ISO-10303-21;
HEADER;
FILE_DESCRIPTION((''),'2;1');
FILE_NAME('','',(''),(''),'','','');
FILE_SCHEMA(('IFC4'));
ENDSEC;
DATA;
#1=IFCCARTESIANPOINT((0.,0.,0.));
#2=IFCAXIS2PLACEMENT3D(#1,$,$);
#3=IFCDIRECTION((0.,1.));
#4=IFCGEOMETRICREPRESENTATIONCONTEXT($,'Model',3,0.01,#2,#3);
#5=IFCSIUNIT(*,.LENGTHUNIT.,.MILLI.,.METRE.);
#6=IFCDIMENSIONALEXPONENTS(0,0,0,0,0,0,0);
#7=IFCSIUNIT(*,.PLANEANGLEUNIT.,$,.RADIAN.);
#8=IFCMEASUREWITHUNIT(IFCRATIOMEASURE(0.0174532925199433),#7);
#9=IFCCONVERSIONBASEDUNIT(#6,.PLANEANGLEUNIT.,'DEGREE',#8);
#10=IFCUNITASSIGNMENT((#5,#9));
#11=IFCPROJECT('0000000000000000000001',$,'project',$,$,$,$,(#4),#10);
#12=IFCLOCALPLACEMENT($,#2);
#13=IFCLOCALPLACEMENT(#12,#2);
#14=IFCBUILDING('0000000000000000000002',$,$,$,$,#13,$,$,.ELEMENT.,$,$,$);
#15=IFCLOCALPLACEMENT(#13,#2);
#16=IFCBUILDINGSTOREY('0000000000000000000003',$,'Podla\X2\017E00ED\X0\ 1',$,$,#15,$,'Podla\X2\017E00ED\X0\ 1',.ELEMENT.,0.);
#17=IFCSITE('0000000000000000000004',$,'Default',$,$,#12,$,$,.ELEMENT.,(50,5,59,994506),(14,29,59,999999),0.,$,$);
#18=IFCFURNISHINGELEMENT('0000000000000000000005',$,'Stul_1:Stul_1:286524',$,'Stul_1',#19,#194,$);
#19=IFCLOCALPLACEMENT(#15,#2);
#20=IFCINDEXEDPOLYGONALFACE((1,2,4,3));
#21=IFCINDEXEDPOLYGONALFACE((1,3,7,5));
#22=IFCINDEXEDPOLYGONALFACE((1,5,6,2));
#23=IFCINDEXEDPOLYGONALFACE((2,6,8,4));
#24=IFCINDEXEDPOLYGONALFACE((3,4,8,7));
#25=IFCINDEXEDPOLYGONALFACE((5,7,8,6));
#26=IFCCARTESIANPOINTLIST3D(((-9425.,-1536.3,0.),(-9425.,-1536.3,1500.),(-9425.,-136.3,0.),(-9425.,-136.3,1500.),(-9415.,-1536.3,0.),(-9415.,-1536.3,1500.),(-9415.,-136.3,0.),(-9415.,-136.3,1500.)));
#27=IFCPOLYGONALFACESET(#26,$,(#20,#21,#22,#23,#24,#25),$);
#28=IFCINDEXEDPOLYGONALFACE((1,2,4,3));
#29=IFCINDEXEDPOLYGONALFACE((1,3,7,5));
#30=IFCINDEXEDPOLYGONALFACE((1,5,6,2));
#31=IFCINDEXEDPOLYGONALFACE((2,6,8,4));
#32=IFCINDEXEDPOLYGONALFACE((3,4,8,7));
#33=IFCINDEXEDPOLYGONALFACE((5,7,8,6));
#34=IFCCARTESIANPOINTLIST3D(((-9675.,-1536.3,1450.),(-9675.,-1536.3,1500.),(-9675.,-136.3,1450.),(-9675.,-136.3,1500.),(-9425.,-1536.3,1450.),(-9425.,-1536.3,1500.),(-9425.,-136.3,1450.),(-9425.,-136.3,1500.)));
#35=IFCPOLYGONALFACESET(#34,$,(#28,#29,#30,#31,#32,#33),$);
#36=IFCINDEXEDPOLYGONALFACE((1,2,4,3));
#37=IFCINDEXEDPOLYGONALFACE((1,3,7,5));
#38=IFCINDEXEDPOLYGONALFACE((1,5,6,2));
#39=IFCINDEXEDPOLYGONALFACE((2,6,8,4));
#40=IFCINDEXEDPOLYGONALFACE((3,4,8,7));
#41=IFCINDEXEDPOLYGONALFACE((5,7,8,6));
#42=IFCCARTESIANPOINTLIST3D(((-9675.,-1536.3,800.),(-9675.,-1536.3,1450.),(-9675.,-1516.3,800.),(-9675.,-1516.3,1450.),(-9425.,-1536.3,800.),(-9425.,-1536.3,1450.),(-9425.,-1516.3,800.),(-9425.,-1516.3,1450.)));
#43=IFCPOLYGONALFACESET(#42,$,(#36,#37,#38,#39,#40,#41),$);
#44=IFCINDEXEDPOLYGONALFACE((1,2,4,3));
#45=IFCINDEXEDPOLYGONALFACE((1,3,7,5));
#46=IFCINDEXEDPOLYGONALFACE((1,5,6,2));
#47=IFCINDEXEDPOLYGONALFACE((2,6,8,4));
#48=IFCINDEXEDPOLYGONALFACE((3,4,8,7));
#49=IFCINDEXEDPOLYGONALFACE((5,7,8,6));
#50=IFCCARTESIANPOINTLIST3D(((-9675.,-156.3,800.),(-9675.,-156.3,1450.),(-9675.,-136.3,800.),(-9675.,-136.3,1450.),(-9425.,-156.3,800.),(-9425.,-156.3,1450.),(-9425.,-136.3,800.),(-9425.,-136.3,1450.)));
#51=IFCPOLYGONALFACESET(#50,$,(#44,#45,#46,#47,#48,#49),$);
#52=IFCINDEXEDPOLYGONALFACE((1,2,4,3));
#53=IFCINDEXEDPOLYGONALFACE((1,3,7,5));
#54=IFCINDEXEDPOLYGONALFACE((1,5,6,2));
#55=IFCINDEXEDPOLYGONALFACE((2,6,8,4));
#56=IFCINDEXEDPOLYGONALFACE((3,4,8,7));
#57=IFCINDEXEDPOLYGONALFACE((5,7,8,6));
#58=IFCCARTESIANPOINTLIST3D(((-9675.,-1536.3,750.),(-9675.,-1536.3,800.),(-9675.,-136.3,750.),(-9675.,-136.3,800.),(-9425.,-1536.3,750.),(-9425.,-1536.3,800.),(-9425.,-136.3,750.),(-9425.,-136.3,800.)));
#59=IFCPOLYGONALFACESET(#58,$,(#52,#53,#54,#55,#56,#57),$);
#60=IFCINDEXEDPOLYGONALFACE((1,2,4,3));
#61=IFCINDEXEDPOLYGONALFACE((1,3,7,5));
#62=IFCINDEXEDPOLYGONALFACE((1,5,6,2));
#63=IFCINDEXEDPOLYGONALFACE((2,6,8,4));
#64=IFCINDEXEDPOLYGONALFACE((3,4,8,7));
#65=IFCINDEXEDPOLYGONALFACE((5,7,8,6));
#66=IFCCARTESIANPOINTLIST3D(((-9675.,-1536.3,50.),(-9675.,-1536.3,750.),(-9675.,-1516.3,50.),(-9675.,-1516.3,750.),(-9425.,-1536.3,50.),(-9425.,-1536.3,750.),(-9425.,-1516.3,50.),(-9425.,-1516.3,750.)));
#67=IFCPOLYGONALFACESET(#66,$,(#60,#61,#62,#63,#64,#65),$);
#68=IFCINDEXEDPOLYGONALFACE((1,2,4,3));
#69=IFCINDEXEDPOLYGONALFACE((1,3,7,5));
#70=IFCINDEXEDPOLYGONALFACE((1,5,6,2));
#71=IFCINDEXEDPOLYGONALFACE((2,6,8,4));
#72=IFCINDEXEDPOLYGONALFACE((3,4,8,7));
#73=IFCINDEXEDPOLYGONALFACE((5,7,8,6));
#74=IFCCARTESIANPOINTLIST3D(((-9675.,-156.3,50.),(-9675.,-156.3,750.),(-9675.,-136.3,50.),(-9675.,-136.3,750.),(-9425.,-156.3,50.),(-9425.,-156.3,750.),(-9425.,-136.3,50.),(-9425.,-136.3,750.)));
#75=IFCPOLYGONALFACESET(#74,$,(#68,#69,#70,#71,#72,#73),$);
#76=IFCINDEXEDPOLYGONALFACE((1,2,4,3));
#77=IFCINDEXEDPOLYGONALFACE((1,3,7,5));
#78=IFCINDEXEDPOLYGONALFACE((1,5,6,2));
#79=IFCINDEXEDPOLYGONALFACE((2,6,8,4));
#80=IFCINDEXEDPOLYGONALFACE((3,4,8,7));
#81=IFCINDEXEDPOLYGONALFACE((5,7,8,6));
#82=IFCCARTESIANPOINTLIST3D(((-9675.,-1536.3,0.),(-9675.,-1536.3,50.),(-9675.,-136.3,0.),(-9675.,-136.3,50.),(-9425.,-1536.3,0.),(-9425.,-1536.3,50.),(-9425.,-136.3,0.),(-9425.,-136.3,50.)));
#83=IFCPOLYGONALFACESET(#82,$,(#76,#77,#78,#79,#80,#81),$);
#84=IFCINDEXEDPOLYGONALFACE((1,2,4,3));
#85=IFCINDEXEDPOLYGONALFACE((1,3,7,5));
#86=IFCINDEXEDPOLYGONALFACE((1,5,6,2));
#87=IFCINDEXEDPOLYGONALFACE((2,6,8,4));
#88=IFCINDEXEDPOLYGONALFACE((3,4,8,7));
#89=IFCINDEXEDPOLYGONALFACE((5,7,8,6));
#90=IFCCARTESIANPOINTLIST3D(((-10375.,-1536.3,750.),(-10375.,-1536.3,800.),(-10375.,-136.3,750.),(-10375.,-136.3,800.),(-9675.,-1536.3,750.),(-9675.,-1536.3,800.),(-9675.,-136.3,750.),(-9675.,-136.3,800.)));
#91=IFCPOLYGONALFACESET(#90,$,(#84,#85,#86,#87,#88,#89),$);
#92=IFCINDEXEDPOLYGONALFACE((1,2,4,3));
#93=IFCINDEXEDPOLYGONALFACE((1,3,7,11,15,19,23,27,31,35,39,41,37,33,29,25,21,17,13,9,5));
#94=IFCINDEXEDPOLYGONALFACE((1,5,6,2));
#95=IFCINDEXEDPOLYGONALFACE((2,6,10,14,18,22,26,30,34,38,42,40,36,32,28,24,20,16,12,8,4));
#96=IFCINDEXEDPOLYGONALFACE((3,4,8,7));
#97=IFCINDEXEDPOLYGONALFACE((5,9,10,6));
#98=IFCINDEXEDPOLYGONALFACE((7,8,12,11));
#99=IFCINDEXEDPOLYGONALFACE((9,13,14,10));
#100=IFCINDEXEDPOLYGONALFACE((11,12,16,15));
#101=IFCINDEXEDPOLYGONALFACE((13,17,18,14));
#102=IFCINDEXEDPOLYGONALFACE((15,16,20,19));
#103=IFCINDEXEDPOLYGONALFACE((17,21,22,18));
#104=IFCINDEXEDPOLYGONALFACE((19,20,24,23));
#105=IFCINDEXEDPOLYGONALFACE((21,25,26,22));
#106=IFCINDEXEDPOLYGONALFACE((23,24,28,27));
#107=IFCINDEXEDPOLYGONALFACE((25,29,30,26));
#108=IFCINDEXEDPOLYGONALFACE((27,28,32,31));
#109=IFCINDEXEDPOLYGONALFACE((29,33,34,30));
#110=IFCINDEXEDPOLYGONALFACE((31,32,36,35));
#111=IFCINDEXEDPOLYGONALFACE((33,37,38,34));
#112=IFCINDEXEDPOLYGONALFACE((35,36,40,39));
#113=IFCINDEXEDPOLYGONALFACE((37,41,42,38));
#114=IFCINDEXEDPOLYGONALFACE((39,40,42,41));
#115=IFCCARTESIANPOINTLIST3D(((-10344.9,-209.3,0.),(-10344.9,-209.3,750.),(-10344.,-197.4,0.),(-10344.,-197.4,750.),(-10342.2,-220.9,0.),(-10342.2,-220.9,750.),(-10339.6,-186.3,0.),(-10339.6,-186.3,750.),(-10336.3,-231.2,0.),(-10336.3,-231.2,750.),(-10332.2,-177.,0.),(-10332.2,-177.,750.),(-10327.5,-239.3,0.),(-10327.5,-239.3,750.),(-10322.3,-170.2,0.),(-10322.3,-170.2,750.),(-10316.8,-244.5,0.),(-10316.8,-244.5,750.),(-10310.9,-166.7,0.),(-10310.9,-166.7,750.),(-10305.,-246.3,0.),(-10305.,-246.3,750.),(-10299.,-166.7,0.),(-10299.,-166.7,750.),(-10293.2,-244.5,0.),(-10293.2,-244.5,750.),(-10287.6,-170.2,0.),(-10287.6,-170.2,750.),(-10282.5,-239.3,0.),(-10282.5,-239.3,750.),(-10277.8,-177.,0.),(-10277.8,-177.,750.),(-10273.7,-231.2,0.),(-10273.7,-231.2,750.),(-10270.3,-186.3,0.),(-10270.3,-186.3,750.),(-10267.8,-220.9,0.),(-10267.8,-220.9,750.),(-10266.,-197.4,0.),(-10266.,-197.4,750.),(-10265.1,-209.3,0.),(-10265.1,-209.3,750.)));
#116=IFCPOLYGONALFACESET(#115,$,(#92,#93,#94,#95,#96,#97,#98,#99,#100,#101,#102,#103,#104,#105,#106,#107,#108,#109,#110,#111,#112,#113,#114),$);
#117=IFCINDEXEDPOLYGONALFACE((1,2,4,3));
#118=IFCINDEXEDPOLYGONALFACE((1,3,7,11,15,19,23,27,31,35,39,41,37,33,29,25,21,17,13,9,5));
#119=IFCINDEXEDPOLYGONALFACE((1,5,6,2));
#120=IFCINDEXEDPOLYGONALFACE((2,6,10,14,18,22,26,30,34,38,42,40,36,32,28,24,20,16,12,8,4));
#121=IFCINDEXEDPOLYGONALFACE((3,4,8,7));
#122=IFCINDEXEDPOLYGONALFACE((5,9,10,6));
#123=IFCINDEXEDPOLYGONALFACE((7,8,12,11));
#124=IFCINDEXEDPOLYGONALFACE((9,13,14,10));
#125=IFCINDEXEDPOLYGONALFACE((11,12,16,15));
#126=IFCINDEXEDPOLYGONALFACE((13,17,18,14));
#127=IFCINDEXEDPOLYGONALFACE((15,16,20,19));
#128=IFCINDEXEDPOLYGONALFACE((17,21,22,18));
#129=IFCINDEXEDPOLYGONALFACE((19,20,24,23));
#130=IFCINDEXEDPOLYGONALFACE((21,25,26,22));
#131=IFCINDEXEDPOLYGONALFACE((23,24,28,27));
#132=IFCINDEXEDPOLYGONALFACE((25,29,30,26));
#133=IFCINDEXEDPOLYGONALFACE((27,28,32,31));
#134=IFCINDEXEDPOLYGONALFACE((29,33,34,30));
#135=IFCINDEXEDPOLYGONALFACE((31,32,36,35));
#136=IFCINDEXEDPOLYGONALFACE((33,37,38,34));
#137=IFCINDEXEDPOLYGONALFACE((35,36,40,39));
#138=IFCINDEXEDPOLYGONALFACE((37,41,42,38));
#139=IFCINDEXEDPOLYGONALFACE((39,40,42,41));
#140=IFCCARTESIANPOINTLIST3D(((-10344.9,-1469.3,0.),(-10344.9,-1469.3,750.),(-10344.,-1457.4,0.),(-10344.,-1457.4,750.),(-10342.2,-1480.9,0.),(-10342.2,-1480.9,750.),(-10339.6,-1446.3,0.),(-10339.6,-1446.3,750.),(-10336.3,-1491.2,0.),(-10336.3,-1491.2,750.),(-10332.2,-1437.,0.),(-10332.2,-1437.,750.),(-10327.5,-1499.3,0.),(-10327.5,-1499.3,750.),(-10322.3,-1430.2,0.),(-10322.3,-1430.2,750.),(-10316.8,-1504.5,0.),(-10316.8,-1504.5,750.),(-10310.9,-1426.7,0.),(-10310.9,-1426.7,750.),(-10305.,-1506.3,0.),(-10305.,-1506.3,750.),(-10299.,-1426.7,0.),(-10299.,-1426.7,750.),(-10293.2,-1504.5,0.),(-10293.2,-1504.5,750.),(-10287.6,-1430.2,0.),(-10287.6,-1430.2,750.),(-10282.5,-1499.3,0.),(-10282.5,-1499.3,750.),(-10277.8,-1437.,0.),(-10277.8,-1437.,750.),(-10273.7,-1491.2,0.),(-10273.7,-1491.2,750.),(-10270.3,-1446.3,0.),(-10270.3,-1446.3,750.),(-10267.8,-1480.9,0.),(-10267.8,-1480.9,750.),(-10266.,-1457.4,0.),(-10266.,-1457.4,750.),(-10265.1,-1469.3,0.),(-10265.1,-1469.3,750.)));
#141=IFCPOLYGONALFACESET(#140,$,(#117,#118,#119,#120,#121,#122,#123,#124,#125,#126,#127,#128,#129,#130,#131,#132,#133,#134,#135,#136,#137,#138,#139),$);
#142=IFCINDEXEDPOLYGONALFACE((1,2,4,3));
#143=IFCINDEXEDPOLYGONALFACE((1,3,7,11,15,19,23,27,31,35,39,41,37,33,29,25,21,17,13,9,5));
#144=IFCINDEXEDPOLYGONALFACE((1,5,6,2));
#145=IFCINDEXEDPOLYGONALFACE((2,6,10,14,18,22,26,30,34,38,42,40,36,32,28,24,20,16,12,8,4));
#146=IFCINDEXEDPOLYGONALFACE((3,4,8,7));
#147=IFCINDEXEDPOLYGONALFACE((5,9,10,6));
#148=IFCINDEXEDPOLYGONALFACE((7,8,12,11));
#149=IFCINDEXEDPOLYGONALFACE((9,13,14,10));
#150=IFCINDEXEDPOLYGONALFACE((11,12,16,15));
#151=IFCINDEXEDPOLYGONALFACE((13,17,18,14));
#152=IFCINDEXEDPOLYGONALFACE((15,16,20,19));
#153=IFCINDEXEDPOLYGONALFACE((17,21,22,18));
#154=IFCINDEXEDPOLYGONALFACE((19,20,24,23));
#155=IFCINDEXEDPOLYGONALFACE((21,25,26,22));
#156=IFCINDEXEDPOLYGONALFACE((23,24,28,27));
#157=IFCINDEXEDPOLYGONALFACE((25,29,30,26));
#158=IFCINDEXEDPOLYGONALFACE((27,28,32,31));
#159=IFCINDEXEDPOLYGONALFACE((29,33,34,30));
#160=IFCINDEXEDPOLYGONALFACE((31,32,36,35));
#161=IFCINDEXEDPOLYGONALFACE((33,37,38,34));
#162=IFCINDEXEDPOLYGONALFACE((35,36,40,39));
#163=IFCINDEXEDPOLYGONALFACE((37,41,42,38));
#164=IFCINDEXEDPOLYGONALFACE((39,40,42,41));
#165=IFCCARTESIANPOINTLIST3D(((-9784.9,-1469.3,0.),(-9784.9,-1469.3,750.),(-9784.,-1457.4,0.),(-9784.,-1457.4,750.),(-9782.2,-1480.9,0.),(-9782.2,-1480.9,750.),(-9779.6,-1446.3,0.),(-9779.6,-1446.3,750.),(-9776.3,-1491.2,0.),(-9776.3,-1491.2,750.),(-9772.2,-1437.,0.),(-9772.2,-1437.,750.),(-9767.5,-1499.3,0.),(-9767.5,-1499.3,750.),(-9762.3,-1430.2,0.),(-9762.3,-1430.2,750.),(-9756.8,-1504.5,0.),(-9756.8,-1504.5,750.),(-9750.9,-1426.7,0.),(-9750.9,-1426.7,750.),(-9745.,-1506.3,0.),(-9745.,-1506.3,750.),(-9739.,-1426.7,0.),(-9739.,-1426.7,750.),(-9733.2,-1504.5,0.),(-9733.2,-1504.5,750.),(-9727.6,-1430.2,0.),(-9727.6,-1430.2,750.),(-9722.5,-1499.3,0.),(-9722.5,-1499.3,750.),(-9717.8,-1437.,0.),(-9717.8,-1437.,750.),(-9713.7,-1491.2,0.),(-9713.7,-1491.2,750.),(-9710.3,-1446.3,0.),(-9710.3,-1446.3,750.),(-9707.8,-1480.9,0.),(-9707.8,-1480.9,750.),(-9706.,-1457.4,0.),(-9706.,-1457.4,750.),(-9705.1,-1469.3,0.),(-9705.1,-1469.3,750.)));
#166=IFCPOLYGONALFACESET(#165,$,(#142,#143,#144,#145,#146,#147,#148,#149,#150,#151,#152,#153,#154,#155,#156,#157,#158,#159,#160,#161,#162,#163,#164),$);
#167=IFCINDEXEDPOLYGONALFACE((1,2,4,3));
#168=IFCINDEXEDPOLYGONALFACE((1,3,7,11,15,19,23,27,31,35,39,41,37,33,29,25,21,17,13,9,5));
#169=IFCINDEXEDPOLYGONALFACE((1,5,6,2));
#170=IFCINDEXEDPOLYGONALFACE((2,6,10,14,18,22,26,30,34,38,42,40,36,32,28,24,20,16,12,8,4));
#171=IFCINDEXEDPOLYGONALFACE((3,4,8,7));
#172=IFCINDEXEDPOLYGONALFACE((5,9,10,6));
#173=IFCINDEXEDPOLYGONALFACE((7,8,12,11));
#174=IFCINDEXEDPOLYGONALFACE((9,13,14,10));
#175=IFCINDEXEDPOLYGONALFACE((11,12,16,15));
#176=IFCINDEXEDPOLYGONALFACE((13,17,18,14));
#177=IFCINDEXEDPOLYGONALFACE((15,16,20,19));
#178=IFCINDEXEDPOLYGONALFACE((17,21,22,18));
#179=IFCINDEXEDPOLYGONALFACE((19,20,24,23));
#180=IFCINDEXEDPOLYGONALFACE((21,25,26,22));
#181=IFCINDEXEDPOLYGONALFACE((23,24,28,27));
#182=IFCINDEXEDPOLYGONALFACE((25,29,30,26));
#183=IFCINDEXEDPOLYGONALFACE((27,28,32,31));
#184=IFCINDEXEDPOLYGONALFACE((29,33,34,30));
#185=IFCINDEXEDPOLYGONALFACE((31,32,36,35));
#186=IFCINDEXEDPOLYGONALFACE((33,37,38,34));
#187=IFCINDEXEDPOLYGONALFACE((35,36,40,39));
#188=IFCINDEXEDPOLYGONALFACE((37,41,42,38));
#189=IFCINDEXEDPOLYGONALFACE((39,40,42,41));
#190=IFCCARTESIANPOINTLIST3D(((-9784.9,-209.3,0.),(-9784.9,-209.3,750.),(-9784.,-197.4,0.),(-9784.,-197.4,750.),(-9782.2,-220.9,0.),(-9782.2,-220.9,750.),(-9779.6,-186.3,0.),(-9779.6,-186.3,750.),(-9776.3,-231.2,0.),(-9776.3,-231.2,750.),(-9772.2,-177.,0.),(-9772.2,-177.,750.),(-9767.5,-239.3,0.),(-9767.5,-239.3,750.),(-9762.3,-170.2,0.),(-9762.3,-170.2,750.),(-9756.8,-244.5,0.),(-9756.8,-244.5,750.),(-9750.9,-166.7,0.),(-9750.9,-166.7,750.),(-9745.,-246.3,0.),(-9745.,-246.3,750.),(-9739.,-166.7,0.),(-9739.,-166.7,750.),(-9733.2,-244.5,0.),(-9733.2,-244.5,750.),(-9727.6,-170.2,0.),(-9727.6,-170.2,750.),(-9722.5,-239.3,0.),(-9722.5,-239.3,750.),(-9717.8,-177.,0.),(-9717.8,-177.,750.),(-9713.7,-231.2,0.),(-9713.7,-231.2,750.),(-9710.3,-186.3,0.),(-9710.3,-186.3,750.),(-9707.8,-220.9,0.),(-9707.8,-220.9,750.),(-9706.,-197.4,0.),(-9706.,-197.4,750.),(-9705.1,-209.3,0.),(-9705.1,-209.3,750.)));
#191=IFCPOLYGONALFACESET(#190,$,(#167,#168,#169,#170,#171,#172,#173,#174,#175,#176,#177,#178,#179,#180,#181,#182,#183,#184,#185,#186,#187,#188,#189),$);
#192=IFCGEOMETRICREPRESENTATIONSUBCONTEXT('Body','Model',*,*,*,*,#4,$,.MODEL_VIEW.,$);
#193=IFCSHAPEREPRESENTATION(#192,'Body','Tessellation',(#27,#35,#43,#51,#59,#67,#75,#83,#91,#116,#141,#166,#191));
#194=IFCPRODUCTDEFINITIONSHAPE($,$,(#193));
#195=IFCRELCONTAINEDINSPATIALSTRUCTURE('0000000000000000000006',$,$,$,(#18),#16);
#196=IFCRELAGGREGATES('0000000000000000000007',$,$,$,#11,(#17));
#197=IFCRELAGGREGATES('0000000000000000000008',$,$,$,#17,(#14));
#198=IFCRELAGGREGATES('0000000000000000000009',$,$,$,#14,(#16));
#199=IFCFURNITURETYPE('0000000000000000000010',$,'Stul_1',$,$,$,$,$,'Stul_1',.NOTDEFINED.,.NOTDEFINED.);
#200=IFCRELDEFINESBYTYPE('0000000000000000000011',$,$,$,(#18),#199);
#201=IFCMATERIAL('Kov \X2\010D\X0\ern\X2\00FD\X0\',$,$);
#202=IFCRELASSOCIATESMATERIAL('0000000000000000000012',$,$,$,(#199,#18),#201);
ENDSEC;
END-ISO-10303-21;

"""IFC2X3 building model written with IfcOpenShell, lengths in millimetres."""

from ifc_helpers import new_model, entity, si_unit, converted_unit, direction, frame, frame_2d, origin, origin_2d_with_axis, place, context, subcontext, project, spatial, rectangle, circle, extrude, source, transform, mapped, material, type_object, type_shapes, element, save


model = new_model("IFC2X3")

# Units and contexts
model_context = context("Model", 3, precision=0.01, world=origin(), true_north=direction((0.0, 1.0)))
body_context = subcontext(model_context, "Body", "Model", "MODEL_VIEW")
ifc_project = project(units=[si_unit("LENGTHUNIT", "METRE", prefix="MILLI"), converted_unit("PLANEANGLEUNIT", "DEGREE", entity("IfcRatioMeasure", 0.0174532925199433), si_unit("PLANEANGLEUNIT", "RADIAN"), dimensions=[0, 0, 0, 0, 0, 0, 0])], contexts=[model_context])

# Site, building, storey
site_placement = place(None, origin())
site = spatial("IfcSite", under=ifc_project, at=site_placement, Name="Default", CompositionType="ELEMENT", RefLatitude=(50, 5, 59, 994506), RefLongitude=(14, 29, 59, 999999), RefElevation=0.0)
building_placement = place(site_placement, origin())
building = spatial("IfcBuilding", under=site, at=building_placement, CompositionType="ELEMENT")
storey_placement = place(building_placement, origin())
storey = spatial("IfcBuildingStorey", under=building, at=storey_placement, Name="Podlaží 1", LongName="Podlaží 1", CompositionType="ELEMENT", Elevation=0.0)

# Furnishing element
ifc_material_1 = material(Name="Kov černý")
furniture_type = type_object("IfcFurnitureType", Name="Stul_1", ElementType="Stul_1", material=ifc_material_1)
shared_shape_1 = source(origin(), body_context, "Body", "SweptSolid", [
    extrude(rectangle(XDim=1400.0, YDim=10.0, at=origin_2d_with_axis()), frame((0.0, 605.0, 0.0), z_axis=(0.0, 0.0, 1.0), x_axis=(-1.0, 0.0, 0.0)), (0.0, 0.0, 1.0), 1500.0),
    extrude(rectangle(XDim=1400.0, YDim=250.0, at=frame_2d((0.0, 0.0), x_axis=(1.0, 0.0))), frame((0.0, 475.0, 1450.0), z_axis=(0.0, 0.0, 1.0), x_axis=(-1.0, 0.0, 0.0)), (0.0, 0.0, 1.0), 50.0),
    extrude(rectangle(XDim=20.0, YDim=250.0, at=origin_2d_with_axis()), frame((690.0, 475.0, 800.0), z_axis=(0.0, 0.0, 1.0), x_axis=(-1.0, 0.0, 0.0)), (0.0, 0.0, 1.0), 650.0),
    extrude(rectangle(XDim=20.0, YDim=250.0, at=frame_2d((0.0, 0.0), x_axis=(1.0, 0.0))), frame((-690.0, 475.0, 800.0), z_axis=(0.0, 0.0, 1.0), x_axis=(-1.0, 0.0, 0.0)), (0.0, 0.0, 1.0), 650.0),
    extrude(rectangle(XDim=1400.0, YDim=250.0, at=origin_2d_with_axis()), frame((0.0, 475.0, 750.0), z_axis=(0.0, 0.0, 1.0), x_axis=(-1.0, 0.0, 0.0)), (0.0, 0.0, 1.0), 50.0),
    extrude(rectangle(XDim=20.0, YDim=250.0, at=origin_2d_with_axis()), frame((690.0, 475.0, 50.0), z_axis=(0.0, 0.0, 1.0), x_axis=(-1.0, 0.0, 0.0)), (0.0, 0.0, 1.0), 700.0),
    extrude(rectangle(XDim=20.0, YDim=250.0, at=frame_2d((0.0, 0.0), x_axis=(1.0, 0.0))), frame((-690.0, 475.0, 50.0), z_axis=(0.0, 0.0, 1.0), x_axis=(-1.0, 0.0, 0.0)), (0.0, 0.0, 1.0), 700.0),
    extrude(rectangle(XDim=1400.0, YDim=250.0, at=origin_2d_with_axis()), frame((0.0, 475.0, 0.0), z_axis=(0.0, 0.0, 1.0), x_axis=(-1.0, 0.0, 0.0)), (0.0, 0.0, 1.0), 50.0),
    extrude(rectangle(XDim=1400.0, YDim=700.0, at=origin_2d_with_axis()), frame((0.0, 0.0, 750.0), z_axis=(0.0, 0.0, 1.0), x_axis=(-1.0, 0.0, 0.0)), (0.0, 0.0, 1.0), 50.0),
    extrude(circle(Radius=40.0, at=frame_2d((0.0, 0.0), x_axis=(1.0, 0.0))), frame((-630.0, -280.0, 0.0)), (0.0, 0.0, 1.0), 750.0),
    extrude(circle(Radius=40.0, at=frame_2d((0.0, 0.0), x_axis=(1.0, 0.0))), frame((630.0, -280.0, 0.0)), (0.0, 0.0, 1.0), 750.0),
    extrude(circle(Radius=40.0, at=frame_2d((0.0, 0.0), x_axis=(1.0, 0.0))), frame((630.0, 280.0, 0.0)), (0.0, 0.0, 1.0), 750.0),
    extrude(circle(Radius=40.0, at=frame_2d((0.0, 0.0), x_axis=(1.0, 0.0))), frame((-630.0, 280.0, 0.0)), (0.0, 0.0, 1.0), 750.0),
])
type_shapes(furniture_type, [shared_shape_1])
for number, where, z_axis, x_axis, name in (
    (1, (-10025.0, -836.3, 0.0), (0.0, 0.0, 1.0), (0.0, -1.0, 0.0), "Stul_1:Stul_1:286524"),
):
    element("IfcFurnishingElement", number, at=place(storey_placement, frame(where, z_axis=z_axis, x_axis=x_axis)), inside=storey, type_object=furniture_type, material=ifc_material_1, Name=name, ObjectType="Stul_1", context=body_context, shape_type="MappedRepresentation", body=[
        mapped(shared_shape_1, transform((0.0, 0.0, 0.0), scale=1.0)),
    ])

save(model, "model.ifc")
